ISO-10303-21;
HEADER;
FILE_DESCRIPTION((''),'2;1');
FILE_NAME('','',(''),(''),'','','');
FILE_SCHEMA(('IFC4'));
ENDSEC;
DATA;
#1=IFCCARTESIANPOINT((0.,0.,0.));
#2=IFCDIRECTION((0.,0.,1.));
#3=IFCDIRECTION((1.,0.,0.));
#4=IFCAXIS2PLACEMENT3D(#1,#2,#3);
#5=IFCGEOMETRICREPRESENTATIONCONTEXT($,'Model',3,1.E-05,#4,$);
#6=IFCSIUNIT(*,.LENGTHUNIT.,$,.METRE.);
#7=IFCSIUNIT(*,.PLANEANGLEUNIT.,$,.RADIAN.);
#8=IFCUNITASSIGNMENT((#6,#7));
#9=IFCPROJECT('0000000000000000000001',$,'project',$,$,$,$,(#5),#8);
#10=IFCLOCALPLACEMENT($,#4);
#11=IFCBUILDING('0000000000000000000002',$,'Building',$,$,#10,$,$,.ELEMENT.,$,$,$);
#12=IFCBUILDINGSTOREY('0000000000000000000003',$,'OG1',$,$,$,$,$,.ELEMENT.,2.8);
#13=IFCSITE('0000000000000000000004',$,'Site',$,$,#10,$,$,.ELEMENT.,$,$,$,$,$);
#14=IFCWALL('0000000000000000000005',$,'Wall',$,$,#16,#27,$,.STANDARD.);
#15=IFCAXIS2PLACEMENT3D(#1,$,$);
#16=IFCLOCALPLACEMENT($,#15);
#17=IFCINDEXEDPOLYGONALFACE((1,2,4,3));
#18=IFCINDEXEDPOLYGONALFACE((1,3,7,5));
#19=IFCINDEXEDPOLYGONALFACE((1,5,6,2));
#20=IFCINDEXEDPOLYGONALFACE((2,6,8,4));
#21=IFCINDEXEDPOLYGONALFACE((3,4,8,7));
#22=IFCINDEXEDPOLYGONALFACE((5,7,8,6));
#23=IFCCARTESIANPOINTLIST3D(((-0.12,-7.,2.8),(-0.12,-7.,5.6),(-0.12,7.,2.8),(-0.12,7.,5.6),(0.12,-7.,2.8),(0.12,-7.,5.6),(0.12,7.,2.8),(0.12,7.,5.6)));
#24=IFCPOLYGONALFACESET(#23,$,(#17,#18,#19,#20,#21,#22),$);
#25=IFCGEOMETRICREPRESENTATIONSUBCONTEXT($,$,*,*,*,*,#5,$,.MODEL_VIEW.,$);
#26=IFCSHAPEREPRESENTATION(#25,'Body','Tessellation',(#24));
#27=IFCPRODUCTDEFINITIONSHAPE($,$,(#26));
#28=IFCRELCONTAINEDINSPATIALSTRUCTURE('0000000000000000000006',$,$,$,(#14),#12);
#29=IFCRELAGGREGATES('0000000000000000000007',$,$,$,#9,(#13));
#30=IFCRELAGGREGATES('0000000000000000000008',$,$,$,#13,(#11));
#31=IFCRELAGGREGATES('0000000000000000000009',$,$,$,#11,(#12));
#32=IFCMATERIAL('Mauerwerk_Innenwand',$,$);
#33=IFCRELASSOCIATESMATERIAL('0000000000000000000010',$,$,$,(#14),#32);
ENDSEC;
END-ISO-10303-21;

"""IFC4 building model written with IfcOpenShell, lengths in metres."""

from ifc_helpers import new_model, si_unit, frame, frame_2d, origin, origin_with_axes, place, context, subcontext, project, spatial, rectangle, extrude, material, element, save


model = new_model("IFC4")

# Units and contexts
model_context = context("Model", 3, precision=1e-05, world=origin_with_axes())
sub_context = subcontext(model_context, None, None, "MODEL_VIEW")
ifc_project = project(units=[si_unit("LENGTHUNIT", "METRE"), si_unit("PLANEANGLEUNIT", "RADIAN")], contexts=[model_context])

# Site, building, storey
placement_1 = place(None, origin_with_axes())
site = spatial("IfcSite", under=ifc_project, at=placement_1, Name="Site", CompositionType="ELEMENT")
building = spatial("IfcBuilding", under=site, at=placement_1, Name="Building", CompositionType="ELEMENT")
storey = spatial("IfcBuildingStorey", under=building, Name="OG1", CompositionType="ELEMENT", Elevation=2.8)

# Wall
ifc_material = material(Name="Mauerwerk_Innenwand")
placement_2 = place(None, origin_with_axes())
placement_3 = place(placement_2, frame((0.0, 0.0, 2.8)))
wall_placement = place(placement_3, frame((0.0, -7.0, 0.0), x_axis=(0.0, 1.0, 0.0)))
element("IfcWall", 1, at=wall_placement, inside=storey, material=ifc_material, Name="Wall", PredefinedType="STANDARD", context=sub_context, shape_type="SweptSolid", body=[
    extrude(rectangle(XDim=14.0, YDim=0.24, at=frame_2d((7.0, 0.0))), origin(), (0.0, 0.0, 1.0), 2.8),
])

save(model, "model.ifc")
